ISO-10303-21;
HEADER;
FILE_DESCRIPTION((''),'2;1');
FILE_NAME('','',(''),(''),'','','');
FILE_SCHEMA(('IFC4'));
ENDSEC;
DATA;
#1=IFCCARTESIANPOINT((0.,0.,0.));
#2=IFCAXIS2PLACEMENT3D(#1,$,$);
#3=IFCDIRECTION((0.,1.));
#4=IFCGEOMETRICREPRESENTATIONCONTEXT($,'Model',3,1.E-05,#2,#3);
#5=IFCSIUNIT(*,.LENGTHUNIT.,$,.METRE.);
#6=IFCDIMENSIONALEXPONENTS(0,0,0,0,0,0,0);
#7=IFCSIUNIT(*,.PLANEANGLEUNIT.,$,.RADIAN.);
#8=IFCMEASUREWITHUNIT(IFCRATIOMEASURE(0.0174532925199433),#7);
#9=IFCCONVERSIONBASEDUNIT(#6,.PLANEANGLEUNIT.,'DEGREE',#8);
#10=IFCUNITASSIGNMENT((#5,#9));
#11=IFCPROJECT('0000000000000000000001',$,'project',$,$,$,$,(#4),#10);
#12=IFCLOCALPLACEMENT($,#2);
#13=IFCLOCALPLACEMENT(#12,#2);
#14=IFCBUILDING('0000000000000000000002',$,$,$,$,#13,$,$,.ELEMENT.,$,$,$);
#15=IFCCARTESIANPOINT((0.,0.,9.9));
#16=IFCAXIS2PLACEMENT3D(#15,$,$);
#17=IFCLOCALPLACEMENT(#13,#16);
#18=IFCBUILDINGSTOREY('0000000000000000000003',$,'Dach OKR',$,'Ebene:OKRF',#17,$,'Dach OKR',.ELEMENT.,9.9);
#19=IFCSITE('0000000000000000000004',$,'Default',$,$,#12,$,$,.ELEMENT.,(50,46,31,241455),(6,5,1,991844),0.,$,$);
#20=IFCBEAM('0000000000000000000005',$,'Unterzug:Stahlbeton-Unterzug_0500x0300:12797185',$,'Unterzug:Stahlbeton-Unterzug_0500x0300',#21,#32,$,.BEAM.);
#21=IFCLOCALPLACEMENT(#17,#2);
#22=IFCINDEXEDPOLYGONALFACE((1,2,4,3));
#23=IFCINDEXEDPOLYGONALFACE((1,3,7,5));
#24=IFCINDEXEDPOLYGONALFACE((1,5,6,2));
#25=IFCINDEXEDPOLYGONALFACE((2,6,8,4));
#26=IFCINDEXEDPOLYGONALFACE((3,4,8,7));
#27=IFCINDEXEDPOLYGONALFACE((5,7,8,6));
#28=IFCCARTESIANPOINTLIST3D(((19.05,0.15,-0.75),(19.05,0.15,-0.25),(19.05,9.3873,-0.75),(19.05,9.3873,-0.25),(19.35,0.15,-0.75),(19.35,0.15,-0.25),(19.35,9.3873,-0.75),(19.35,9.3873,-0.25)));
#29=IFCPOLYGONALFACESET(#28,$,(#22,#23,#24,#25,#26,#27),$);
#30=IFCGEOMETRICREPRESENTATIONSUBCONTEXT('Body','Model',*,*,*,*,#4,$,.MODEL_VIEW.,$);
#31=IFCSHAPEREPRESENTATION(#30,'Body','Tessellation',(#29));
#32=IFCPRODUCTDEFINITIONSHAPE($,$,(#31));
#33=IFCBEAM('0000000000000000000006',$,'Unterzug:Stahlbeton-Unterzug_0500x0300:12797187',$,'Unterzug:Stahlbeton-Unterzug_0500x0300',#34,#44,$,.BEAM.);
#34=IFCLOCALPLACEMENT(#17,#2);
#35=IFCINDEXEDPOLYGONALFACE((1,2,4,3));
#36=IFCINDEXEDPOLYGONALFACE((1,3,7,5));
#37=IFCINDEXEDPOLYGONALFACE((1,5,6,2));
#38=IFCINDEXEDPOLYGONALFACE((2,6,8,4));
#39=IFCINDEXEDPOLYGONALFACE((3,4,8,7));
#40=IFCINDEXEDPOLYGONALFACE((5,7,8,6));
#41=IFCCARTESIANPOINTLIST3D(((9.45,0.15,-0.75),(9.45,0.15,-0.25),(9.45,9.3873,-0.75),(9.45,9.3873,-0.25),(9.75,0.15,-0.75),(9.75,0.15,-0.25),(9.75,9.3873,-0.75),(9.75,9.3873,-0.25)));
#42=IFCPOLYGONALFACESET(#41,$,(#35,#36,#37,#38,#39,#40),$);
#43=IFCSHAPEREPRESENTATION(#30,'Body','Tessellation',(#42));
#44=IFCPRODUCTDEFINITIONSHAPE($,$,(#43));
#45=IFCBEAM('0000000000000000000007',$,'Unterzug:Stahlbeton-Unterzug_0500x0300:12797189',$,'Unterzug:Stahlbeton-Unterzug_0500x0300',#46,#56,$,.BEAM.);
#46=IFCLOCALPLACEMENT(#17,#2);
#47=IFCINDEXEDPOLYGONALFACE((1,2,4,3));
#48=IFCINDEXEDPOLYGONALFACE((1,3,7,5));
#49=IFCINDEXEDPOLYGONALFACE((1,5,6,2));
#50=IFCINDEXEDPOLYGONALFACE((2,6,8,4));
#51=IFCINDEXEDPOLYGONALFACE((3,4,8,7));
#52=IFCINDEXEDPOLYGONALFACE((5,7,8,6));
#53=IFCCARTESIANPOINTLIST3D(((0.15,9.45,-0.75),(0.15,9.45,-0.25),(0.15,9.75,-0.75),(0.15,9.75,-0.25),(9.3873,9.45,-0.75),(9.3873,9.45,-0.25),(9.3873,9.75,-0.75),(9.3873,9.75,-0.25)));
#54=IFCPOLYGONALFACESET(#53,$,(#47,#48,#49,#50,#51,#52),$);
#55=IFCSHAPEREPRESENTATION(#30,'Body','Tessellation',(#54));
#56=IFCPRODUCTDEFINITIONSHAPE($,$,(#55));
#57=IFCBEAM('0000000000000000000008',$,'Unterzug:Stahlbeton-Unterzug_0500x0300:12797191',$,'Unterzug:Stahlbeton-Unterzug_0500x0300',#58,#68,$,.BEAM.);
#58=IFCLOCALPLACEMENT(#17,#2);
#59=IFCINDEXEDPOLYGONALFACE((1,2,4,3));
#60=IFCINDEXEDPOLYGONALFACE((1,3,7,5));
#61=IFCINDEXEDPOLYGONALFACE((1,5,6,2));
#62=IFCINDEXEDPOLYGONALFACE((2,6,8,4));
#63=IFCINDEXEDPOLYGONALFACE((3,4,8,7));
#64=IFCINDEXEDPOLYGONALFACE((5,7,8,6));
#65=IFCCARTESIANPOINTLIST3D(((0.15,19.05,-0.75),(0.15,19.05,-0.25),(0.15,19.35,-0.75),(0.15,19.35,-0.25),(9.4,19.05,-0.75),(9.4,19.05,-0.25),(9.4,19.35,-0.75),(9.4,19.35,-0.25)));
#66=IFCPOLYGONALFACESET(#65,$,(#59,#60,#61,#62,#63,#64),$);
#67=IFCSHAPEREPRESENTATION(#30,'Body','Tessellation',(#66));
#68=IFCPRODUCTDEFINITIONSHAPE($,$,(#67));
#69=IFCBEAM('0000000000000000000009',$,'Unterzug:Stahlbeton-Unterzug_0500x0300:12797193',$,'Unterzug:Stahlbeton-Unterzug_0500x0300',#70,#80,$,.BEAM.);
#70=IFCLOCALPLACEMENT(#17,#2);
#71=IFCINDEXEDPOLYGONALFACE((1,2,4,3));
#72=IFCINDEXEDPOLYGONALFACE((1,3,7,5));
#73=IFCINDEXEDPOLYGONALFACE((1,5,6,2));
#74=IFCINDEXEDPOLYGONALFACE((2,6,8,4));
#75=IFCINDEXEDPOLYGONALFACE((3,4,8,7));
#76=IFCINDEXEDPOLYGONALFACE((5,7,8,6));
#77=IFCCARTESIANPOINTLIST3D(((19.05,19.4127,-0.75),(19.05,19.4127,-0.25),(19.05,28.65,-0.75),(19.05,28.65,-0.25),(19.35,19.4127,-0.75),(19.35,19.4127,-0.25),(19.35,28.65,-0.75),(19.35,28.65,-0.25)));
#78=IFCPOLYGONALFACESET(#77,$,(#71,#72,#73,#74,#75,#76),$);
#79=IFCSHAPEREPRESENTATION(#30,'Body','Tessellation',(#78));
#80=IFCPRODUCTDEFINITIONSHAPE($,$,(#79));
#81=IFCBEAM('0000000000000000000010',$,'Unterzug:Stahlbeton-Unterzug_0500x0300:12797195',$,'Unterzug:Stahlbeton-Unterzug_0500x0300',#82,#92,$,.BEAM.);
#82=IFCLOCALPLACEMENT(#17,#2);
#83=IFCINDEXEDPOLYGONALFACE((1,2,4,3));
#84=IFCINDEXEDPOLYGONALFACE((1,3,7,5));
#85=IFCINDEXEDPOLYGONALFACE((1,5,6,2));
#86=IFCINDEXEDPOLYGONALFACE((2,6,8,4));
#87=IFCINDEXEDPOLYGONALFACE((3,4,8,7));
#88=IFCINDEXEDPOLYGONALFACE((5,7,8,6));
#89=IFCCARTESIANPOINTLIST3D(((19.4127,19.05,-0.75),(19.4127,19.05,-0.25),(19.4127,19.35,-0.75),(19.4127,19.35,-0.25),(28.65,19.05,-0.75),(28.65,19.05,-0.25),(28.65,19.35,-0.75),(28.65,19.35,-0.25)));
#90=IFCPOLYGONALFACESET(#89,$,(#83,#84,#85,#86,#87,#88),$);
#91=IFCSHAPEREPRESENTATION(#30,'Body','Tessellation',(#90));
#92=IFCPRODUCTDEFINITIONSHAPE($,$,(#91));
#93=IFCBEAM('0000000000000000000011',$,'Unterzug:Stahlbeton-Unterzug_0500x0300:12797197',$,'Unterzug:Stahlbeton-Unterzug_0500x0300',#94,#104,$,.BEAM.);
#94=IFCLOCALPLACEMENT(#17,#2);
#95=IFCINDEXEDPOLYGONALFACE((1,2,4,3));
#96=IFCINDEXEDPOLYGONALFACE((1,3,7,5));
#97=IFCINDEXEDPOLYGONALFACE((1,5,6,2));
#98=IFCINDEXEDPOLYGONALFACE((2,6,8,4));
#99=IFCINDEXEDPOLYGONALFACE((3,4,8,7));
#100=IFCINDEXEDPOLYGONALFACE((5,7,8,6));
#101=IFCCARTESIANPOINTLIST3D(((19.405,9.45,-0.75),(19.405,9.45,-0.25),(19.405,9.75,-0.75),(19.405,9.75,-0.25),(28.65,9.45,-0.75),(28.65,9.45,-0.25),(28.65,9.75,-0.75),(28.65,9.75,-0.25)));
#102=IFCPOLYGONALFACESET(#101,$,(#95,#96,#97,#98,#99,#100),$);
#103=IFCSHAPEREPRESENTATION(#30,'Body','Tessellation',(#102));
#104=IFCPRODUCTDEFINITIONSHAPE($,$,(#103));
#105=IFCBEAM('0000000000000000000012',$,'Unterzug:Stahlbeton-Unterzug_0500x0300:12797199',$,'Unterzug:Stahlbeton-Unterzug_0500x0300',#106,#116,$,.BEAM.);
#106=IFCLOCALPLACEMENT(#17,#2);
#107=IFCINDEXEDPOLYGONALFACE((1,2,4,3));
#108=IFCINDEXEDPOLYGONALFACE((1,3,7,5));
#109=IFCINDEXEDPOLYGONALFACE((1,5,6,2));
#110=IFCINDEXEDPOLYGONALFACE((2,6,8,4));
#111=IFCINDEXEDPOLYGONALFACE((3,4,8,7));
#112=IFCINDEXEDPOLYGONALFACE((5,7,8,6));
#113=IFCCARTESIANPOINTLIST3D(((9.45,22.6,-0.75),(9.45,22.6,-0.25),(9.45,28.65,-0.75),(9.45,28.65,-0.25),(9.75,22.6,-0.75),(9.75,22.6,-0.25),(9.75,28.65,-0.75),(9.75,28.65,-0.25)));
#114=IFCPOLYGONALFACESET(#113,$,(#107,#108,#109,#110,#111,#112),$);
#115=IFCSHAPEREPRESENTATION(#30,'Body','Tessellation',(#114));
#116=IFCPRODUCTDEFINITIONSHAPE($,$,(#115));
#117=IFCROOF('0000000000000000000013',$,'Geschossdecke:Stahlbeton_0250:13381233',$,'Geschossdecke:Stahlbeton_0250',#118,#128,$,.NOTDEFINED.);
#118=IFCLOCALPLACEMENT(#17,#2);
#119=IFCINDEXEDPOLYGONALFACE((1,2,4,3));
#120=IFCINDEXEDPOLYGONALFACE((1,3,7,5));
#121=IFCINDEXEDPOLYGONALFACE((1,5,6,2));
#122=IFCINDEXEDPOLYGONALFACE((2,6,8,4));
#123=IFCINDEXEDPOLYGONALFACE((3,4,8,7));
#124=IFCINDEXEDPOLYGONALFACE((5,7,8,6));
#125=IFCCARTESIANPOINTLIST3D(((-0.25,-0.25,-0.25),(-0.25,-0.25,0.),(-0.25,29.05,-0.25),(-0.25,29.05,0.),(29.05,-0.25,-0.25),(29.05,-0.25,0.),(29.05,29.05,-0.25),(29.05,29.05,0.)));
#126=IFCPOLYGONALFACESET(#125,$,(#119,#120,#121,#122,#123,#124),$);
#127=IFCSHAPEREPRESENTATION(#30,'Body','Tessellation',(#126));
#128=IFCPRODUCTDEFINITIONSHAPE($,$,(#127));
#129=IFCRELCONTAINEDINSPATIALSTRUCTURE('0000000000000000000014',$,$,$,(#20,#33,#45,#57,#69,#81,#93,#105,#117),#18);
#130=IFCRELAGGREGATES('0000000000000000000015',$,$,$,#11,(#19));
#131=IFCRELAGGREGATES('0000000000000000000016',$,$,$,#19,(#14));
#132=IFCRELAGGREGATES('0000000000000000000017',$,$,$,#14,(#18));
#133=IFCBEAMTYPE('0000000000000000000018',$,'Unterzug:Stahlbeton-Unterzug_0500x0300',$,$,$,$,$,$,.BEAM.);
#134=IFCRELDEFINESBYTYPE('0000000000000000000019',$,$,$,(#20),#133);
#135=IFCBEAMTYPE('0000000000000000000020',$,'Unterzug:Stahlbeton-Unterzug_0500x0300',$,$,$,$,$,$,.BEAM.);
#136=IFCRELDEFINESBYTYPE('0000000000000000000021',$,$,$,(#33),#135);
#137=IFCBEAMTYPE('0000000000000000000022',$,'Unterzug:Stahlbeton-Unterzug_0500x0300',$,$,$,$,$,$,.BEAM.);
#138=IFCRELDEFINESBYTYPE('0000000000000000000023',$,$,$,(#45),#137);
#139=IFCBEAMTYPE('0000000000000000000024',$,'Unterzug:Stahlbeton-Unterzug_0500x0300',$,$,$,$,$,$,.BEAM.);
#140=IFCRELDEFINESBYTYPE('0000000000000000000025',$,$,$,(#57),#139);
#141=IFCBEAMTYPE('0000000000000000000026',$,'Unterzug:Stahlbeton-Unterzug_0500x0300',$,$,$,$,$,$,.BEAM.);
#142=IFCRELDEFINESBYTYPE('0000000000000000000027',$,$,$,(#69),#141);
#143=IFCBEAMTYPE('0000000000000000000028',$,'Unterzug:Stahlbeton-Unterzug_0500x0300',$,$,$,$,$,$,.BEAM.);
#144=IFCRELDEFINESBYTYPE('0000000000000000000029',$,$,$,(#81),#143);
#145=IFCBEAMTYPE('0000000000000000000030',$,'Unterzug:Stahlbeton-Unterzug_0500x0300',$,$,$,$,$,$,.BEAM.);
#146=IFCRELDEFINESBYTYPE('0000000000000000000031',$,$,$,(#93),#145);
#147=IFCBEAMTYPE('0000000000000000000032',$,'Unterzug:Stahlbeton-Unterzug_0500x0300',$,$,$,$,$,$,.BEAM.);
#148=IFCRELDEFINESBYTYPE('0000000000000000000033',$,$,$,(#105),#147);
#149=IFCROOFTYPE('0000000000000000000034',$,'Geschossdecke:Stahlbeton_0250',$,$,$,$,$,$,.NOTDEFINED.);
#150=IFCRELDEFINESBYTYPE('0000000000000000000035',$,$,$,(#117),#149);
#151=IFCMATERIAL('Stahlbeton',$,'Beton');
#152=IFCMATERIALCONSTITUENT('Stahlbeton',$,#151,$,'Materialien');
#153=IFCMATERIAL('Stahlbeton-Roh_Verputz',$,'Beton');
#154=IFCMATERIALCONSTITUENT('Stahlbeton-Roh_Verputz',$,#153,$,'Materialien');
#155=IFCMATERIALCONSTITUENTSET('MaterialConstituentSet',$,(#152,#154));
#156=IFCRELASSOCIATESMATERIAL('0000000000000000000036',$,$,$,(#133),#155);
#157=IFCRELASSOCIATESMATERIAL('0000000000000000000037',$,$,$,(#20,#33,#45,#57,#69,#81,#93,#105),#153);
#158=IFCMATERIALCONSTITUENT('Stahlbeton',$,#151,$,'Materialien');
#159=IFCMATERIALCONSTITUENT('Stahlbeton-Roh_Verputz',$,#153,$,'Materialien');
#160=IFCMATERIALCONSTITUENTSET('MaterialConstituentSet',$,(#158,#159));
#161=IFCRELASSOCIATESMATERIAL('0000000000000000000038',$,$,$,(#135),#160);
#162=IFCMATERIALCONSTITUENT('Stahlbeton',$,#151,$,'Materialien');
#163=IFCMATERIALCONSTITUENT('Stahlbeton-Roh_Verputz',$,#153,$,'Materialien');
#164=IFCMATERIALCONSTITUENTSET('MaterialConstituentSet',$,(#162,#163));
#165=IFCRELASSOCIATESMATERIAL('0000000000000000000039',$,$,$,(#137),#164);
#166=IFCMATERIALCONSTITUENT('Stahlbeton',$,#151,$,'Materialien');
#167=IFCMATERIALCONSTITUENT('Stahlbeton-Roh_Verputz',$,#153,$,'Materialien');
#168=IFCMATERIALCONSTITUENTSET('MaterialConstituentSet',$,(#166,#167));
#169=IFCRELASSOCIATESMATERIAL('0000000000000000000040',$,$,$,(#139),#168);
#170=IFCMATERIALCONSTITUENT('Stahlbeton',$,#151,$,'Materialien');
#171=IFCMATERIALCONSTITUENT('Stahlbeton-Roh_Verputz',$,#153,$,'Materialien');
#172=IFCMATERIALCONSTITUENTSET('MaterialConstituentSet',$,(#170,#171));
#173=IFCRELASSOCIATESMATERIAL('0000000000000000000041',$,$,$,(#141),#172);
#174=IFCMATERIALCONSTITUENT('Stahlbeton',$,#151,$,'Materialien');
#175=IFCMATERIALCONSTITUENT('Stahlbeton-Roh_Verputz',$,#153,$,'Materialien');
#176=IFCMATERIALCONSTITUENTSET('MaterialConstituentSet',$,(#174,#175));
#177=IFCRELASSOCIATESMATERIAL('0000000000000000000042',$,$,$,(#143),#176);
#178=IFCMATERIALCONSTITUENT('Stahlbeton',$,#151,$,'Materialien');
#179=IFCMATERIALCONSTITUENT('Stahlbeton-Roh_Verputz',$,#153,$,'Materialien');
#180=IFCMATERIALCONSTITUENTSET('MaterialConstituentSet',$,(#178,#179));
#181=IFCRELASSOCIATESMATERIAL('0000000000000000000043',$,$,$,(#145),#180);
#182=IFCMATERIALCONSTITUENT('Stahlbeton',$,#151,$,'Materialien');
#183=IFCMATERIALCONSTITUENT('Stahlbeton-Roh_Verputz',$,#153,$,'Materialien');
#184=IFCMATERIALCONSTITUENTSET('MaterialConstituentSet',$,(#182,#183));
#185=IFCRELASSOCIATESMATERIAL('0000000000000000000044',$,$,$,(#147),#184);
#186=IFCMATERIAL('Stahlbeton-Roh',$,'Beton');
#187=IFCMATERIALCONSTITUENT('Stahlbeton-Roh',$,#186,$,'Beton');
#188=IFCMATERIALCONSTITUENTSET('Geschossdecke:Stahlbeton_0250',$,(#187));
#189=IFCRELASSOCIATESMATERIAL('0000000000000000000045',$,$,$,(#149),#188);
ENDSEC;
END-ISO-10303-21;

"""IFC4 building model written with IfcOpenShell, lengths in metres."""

from ifc_helpers import new_model, entity, si_unit, converted_unit, direction, frame, origin, place, context, subcontext, project, spatial, indexed_curve, outline, extrude, source, transform, mapped, material, constituent, constituent_set, type_object, type_shapes, element, save


model = new_model("IFC4")

# Units and contexts
model_context = context("Model", 3, precision=1e-05, world=origin(), true_north=direction((0.0, 1.0)))
body_context = subcontext(model_context, "Body", "Model", "MODEL_VIEW")
ifc_project = project(units=[si_unit("LENGTHUNIT", "METRE"), converted_unit("PLANEANGLEUNIT", "DEGREE", entity("IfcRatioMeasure", 0.0174532925199433), si_unit("PLANEANGLEUNIT", "RADIAN"), dimensions=[0, 0, 0, 0, 0, 0, 0])], contexts=[model_context])

# Site, building, storey
site_placement = place(None, origin())
site = spatial("IfcSite", under=ifc_project, at=site_placement, Name="Default", CompositionType="ELEMENT", RefLatitude=(50, 46, 31, 241455), RefLongitude=(6, 5, 1, 991844), RefElevation=0.0)
building_placement = place(site_placement, origin())
building = spatial("IfcBuilding", under=site, at=building_placement, CompositionType="ELEMENT")
storey_placement = place(building_placement, frame((0.0, 0.0, 9.9)))
storey = spatial("IfcBuildingStorey", under=building, at=storey_placement, Name="Dach OKR", ObjectType="Ebene:OKRF", LongName="Dach OKR", CompositionType="ELEMENT", Elevation=9.9)

# Beams
ifc_material_1 = material(Name="Stahlbeton-Roh_Verputz", Category="Beton")
ifc_material_2 = material(Name="Stahlbeton", Category="Beton")
ifc_constituent_1 = constituent(ifc_material_2, Name="Stahlbeton", Category="Materialien")
ifc_constituent_2 = constituent(ifc_material_1, Name="Stahlbeton-Roh_Verputz", Category="Materialien")
ifc_constituent_set_1 = constituent_set(constituents=[ifc_constituent_1, ifc_constituent_2], Name="MaterialConstituentSet")
beam_type_1 = type_object("IfcBeamType", Name="Unterzug:Stahlbeton-Unterzug_0500x0300", PredefinedType="BEAM", material=ifc_constituent_set_1)
shared_shape_1 = source(origin(), body_context, "Body", "SweptSolid", [
    extrude(outline(indexed_curve([(-0.15, -0.25), (0.15, -0.25), (0.15, 0.25), (-0.15, 0.25), (-0.15, -0.25)], self_intersect=False)), frame((19.2, 9.3873, 9.4), z_axis=(0.0, -1.0, 0.0), x_axis=(-1.0, 0.0, 0.0)), (0.0, 0.0, 1.0), 9.2373),
])
type_shapes(beam_type_1, [shared_shape_1])
beam_1_placement = place(storey_placement, frame((0.0, 0.0, -9.9)))
element("IfcBeam", 1, at=beam_1_placement, inside=storey, type_object=beam_type_1, material=ifc_material_1, Name="Unterzug:Stahlbeton-Unterzug_0500x0300:12797185", ObjectType="Unterzug:Stahlbeton-Unterzug_0500x0300", PredefinedType="BEAM", context=body_context, shape_type="MappedRepresentation", body=[
    mapped(shared_shape_1, transform((0.0, 0.0, 0.0), scale=1.0)),
])
ifc_constituent_3 = constituent(ifc_material_2, Name="Stahlbeton", Category="Materialien")
ifc_constituent_4 = constituent(ifc_material_1, Name="Stahlbeton-Roh_Verputz", Category="Materialien")
ifc_constituent_set_2 = constituent_set(constituents=[ifc_constituent_3, ifc_constituent_4], Name="MaterialConstituentSet")
beam_type_2 = type_object("IfcBeamType", Name="Unterzug:Stahlbeton-Unterzug_0500x0300", PredefinedType="BEAM", material=ifc_constituent_set_2)
shared_shape_2 = source(origin(), body_context, "Body", "SweptSolid", [
    extrude(outline(indexed_curve([(-0.15, -0.25), (0.15, -0.25), (0.15, 0.25), (-0.15, 0.25), (-0.15, -0.25)], self_intersect=False)), frame((9.6, 9.3873, 9.4), z_axis=(0.0, -1.0, 0.0), x_axis=(-1.0, 0.0, 0.0)), (0.0, 0.0, 1.0), 9.2373),
])
type_shapes(beam_type_2, [shared_shape_2])
beam_2_placement = place(storey_placement, frame((0.0, 0.0, -9.9)))
element("IfcBeam", 2, at=beam_2_placement, inside=storey, type_object=beam_type_2, material=ifc_material_1, Name="Unterzug:Stahlbeton-Unterzug_0500x0300:12797187", ObjectType="Unterzug:Stahlbeton-Unterzug_0500x0300", PredefinedType="BEAM", context=body_context, shape_type="MappedRepresentation", body=[
    mapped(shared_shape_2, transform((0.0, 0.0, 0.0), scale=1.0)),
])
ifc_constituent_5 = constituent(ifc_material_2, Name="Stahlbeton", Category="Materialien")
ifc_constituent_6 = constituent(ifc_material_1, Name="Stahlbeton-Roh_Verputz", Category="Materialien")
ifc_constituent_set_3 = constituent_set(constituents=[ifc_constituent_5, ifc_constituent_6], Name="MaterialConstituentSet")
beam_type_3 = type_object("IfcBeamType", Name="Unterzug:Stahlbeton-Unterzug_0500x0300", PredefinedType="BEAM", material=ifc_constituent_set_3)
shared_shape_3 = source(origin(), body_context, "Body", "SweptSolid", [
    extrude(outline(indexed_curve([(-0.25, -0.15), (0.25, -0.15), (0.25, 0.15), (-0.25, 0.15), (-0.25, -0.15)], self_intersect=False)), frame((9.3873, 9.6, 9.4), z_axis=(-1.0, 0.0, 0.0), x_axis=(0.0, 0.0, -1.0)), (0.0, 0.0, 1.0), 9.2373),
])
type_shapes(beam_type_3, [shared_shape_3])
beam_3_placement = place(storey_placement, frame((0.0, 0.0, -9.9)))
element("IfcBeam", 3, at=beam_3_placement, inside=storey, type_object=beam_type_3, material=ifc_material_1, Name="Unterzug:Stahlbeton-Unterzug_0500x0300:12797189", ObjectType="Unterzug:Stahlbeton-Unterzug_0500x0300", PredefinedType="BEAM", context=body_context, shape_type="MappedRepresentation", body=[
    mapped(shared_shape_3, transform((0.0, 0.0, 0.0), scale=1.0)),
])
ifc_constituent_7 = constituent(ifc_material_2, Name="Stahlbeton", Category="Materialien")
ifc_constituent_8 = constituent(ifc_material_1, Name="Stahlbeton-Roh_Verputz", Category="Materialien")
ifc_constituent_set_4 = constituent_set(constituents=[ifc_constituent_7, ifc_constituent_8], Name="MaterialConstituentSet")
beam_type_4 = type_object("IfcBeamType", Name="Unterzug:Stahlbeton-Unterzug_0500x0300", PredefinedType="BEAM", material=ifc_constituent_set_4)
shared_shape_4 = source(origin(), body_context, "Body", "SweptSolid", [
    extrude(outline(indexed_curve([(-0.25, -0.15), (0.25, -0.15), (0.25, 0.15), (-0.25, 0.15), (-0.25, -0.15)], self_intersect=False)), frame((9.4, 19.2, 9.4), z_axis=(-1.0, 0.0, 0.0), x_axis=(0.0, 0.0, -1.0)), (0.0, 0.0, 1.0), 9.25),
])
type_shapes(beam_type_4, [shared_shape_4])
beam_4_placement = place(storey_placement, frame((0.0, 0.0, -9.9)))
element("IfcBeam", 4, at=beam_4_placement, inside=storey, type_object=beam_type_4, material=ifc_material_1, Name="Unterzug:Stahlbeton-Unterzug_0500x0300:12797191", ObjectType="Unterzug:Stahlbeton-Unterzug_0500x0300", PredefinedType="BEAM", context=body_context, shape_type="MappedRepresentation", body=[
    mapped(shared_shape_4, transform((0.0, 0.0, 0.0), scale=1.0)),
])
ifc_constituent_9 = constituent(ifc_material_2, Name="Stahlbeton", Category="Materialien")
ifc_constituent_10 = constituent(ifc_material_1, Name="Stahlbeton-Roh_Verputz", Category="Materialien")
ifc_constituent_set_5 = constituent_set(constituents=[ifc_constituent_9, ifc_constituent_10], Name="MaterialConstituentSet")
beam_type_5 = type_object("IfcBeamType", Name="Unterzug:Stahlbeton-Unterzug_0500x0300", PredefinedType="BEAM", material=ifc_constituent_set_5)
shared_shape_5 = source(origin(), body_context, "Body", "SweptSolid", [
    extrude(outline(indexed_curve([(-0.15, -0.25), (0.15, -0.25), (0.15, 0.25), (-0.15, 0.25), (-0.15, -0.25)], self_intersect=False)), frame((19.2, 19.4127, 9.4), z_axis=(0.0, 1.0, 0.0), x_axis=(-1.0, 0.0, 0.0)), (0.0, 0.0, 1.0), 9.2373),
])
type_shapes(beam_type_5, [shared_shape_5])
beam_5_placement = place(storey_placement, frame((0.0, 0.0, -9.9)))
element("IfcBeam", 5, at=beam_5_placement, inside=storey, type_object=beam_type_5, material=ifc_material_1, Name="Unterzug:Stahlbeton-Unterzug_0500x0300:12797193", ObjectType="Unterzug:Stahlbeton-Unterzug_0500x0300", PredefinedType="BEAM", context=body_context, shape_type="MappedRepresentation", body=[
    mapped(shared_shape_5, transform((0.0, 0.0, 0.0), scale=1.0)),
])
ifc_constituent_11 = constituent(ifc_material_2, Name="Stahlbeton", Category="Materialien")
ifc_constituent_12 = constituent(ifc_material_1, Name="Stahlbeton-Roh_Verputz", Category="Materialien")
ifc_constituent_set_6 = constituent_set(constituents=[ifc_constituent_11, ifc_constituent_12], Name="MaterialConstituentSet")
beam_type_6 = type_object("IfcBeamType", Name="Unterzug:Stahlbeton-Unterzug_0500x0300", PredefinedType="BEAM", material=ifc_constituent_set_6)
shared_shape_6 = source(origin(), body_context, "Body", "SweptSolid", [
    extrude(outline(indexed_curve([(-0.25, -0.15), (0.25, -0.15), (0.25, 0.15), (-0.25, 0.15), (-0.25, -0.15)], self_intersect=False)), frame((19.4127, 19.2, 9.4), z_axis=(1.0, 0.0, 0.0), x_axis=(0.0, 0.0, -1.0)), (0.0, 0.0, 1.0), 9.2373),
])
type_shapes(beam_type_6, [shared_shape_6])
beam_6_placement = place(storey_placement, frame((0.0, 0.0, -9.9)))
element("IfcBeam", 6, at=beam_6_placement, inside=storey, type_object=beam_type_6, material=ifc_material_1, Name="Unterzug:Stahlbeton-Unterzug_0500x0300:12797195", ObjectType="Unterzug:Stahlbeton-Unterzug_0500x0300", PredefinedType="BEAM", context=body_context, shape_type="MappedRepresentation", body=[
    mapped(shared_shape_6, transform((0.0, 0.0, 0.0), scale=1.0)),
])
ifc_constituent_13 = constituent(ifc_material_2, Name="Stahlbeton", Category="Materialien")
ifc_constituent_14 = constituent(ifc_material_1, Name="Stahlbeton-Roh_Verputz", Category="Materialien")
ifc_constituent_set_7 = constituent_set(constituents=[ifc_constituent_13, ifc_constituent_14], Name="MaterialConstituentSet")
beam_type_7 = type_object("IfcBeamType", Name="Unterzug:Stahlbeton-Unterzug_0500x0300", PredefinedType="BEAM", material=ifc_constituent_set_7)
shared_shape_7 = source(origin(), body_context, "Body", "SweptSolid", [
    extrude(outline(indexed_curve([(-0.25, -0.15), (0.25, -0.15), (0.25, 0.15), (-0.25, 0.15), (-0.25, -0.15)], self_intersect=False)), frame((19.405, 9.6, 9.4), z_axis=(1.0, 0.0, 0.0), x_axis=(0.0, 0.0, -1.0)), (0.0, 0.0, 1.0), 9.245),
])
type_shapes(beam_type_7, [shared_shape_7])
beam_7_placement = place(storey_placement, frame((0.0, 0.0, -9.9)))
element("IfcBeam", 7, at=beam_7_placement, inside=storey, type_object=beam_type_7, material=ifc_material_1, Name="Unterzug:Stahlbeton-Unterzug_0500x0300:12797197", ObjectType="Unterzug:Stahlbeton-Unterzug_0500x0300", PredefinedType="BEAM", context=body_context, shape_type="MappedRepresentation", body=[
    mapped(shared_shape_7, transform((0.0, 0.0, 0.0), scale=1.0)),
])
ifc_constituent_15 = constituent(ifc_material_2, Name="Stahlbeton", Category="Materialien")
ifc_constituent_16 = constituent(ifc_material_1, Name="Stahlbeton-Roh_Verputz", Category="Materialien")
ifc_constituent_set_8 = constituent_set(constituents=[ifc_constituent_15, ifc_constituent_16], Name="MaterialConstituentSet")
beam_type_8 = type_object("IfcBeamType", Name="Unterzug:Stahlbeton-Unterzug_0500x0300", PredefinedType="BEAM", material=ifc_constituent_set_8)
shared_shape_8 = source(origin(), body_context, "Body", "SweptSolid", [
    extrude(outline(indexed_curve([(-0.15, -0.25), (0.15, -0.25), (0.15, 0.25), (-0.15, 0.25), (-0.15, -0.25)], self_intersect=False)), frame((9.6, 22.6, 9.4), z_axis=(0.0, 1.0, 0.0), x_axis=(-1.0, 0.0, 0.0)), (0.0, 0.0, 1.0), 6.05),
])
type_shapes(beam_type_8, [shared_shape_8])
beam_8_placement = place(storey_placement, frame((0.0, 0.0, -9.9)))
element("IfcBeam", 8, at=beam_8_placement, inside=storey, type_object=beam_type_8, material=ifc_material_1, Name="Unterzug:Stahlbeton-Unterzug_0500x0300:12797199", ObjectType="Unterzug:Stahlbeton-Unterzug_0500x0300", PredefinedType="BEAM", context=body_context, shape_type="MappedRepresentation", body=[
    mapped(shared_shape_8, transform((0.0, 0.0, 0.0), scale=1.0)),
])

# Roof
ifc_material_3 = material(Name="Stahlbeton-Roh", Category="Beton")
ifc_constituent_17 = constituent(ifc_material_3, Name="Stahlbeton-Roh", Category="Beton")
ifc_constituent_set_9 = constituent_set(constituents=[ifc_constituent_17], Name="Geschossdecke:Stahlbeton_0250")
roof_type = type_object("IfcRoofType", Name="Geschossdecke:Stahlbeton_0250", PredefinedType="NOTDEFINED", material=ifc_constituent_set_9)
roof_placement = place(storey_placement, origin())
element("IfcRoof", 9, at=roof_placement, inside=storey, type_object=roof_type, Name="Geschossdecke:Stahlbeton_0250:13381233", ObjectType="Geschossdecke:Stahlbeton_0250", PredefinedType="NOTDEFINED", context=body_context, shape_type="SweptSolid", body=[
    extrude(outline(indexed_curve([(-14.65, -14.65), (14.65, -14.65), (14.65, 14.65), (-14.65, 14.65), (-14.65, -14.65)], self_intersect=False)), frame((14.4, 14.4, -0.25), z_axis=(0.0, 0.0, 1.0), x_axis=(-1.0, 0.0, 0.0)), (0.0, 0.0, 1.0), 0.25),
])

save(model, "model.ifc")
